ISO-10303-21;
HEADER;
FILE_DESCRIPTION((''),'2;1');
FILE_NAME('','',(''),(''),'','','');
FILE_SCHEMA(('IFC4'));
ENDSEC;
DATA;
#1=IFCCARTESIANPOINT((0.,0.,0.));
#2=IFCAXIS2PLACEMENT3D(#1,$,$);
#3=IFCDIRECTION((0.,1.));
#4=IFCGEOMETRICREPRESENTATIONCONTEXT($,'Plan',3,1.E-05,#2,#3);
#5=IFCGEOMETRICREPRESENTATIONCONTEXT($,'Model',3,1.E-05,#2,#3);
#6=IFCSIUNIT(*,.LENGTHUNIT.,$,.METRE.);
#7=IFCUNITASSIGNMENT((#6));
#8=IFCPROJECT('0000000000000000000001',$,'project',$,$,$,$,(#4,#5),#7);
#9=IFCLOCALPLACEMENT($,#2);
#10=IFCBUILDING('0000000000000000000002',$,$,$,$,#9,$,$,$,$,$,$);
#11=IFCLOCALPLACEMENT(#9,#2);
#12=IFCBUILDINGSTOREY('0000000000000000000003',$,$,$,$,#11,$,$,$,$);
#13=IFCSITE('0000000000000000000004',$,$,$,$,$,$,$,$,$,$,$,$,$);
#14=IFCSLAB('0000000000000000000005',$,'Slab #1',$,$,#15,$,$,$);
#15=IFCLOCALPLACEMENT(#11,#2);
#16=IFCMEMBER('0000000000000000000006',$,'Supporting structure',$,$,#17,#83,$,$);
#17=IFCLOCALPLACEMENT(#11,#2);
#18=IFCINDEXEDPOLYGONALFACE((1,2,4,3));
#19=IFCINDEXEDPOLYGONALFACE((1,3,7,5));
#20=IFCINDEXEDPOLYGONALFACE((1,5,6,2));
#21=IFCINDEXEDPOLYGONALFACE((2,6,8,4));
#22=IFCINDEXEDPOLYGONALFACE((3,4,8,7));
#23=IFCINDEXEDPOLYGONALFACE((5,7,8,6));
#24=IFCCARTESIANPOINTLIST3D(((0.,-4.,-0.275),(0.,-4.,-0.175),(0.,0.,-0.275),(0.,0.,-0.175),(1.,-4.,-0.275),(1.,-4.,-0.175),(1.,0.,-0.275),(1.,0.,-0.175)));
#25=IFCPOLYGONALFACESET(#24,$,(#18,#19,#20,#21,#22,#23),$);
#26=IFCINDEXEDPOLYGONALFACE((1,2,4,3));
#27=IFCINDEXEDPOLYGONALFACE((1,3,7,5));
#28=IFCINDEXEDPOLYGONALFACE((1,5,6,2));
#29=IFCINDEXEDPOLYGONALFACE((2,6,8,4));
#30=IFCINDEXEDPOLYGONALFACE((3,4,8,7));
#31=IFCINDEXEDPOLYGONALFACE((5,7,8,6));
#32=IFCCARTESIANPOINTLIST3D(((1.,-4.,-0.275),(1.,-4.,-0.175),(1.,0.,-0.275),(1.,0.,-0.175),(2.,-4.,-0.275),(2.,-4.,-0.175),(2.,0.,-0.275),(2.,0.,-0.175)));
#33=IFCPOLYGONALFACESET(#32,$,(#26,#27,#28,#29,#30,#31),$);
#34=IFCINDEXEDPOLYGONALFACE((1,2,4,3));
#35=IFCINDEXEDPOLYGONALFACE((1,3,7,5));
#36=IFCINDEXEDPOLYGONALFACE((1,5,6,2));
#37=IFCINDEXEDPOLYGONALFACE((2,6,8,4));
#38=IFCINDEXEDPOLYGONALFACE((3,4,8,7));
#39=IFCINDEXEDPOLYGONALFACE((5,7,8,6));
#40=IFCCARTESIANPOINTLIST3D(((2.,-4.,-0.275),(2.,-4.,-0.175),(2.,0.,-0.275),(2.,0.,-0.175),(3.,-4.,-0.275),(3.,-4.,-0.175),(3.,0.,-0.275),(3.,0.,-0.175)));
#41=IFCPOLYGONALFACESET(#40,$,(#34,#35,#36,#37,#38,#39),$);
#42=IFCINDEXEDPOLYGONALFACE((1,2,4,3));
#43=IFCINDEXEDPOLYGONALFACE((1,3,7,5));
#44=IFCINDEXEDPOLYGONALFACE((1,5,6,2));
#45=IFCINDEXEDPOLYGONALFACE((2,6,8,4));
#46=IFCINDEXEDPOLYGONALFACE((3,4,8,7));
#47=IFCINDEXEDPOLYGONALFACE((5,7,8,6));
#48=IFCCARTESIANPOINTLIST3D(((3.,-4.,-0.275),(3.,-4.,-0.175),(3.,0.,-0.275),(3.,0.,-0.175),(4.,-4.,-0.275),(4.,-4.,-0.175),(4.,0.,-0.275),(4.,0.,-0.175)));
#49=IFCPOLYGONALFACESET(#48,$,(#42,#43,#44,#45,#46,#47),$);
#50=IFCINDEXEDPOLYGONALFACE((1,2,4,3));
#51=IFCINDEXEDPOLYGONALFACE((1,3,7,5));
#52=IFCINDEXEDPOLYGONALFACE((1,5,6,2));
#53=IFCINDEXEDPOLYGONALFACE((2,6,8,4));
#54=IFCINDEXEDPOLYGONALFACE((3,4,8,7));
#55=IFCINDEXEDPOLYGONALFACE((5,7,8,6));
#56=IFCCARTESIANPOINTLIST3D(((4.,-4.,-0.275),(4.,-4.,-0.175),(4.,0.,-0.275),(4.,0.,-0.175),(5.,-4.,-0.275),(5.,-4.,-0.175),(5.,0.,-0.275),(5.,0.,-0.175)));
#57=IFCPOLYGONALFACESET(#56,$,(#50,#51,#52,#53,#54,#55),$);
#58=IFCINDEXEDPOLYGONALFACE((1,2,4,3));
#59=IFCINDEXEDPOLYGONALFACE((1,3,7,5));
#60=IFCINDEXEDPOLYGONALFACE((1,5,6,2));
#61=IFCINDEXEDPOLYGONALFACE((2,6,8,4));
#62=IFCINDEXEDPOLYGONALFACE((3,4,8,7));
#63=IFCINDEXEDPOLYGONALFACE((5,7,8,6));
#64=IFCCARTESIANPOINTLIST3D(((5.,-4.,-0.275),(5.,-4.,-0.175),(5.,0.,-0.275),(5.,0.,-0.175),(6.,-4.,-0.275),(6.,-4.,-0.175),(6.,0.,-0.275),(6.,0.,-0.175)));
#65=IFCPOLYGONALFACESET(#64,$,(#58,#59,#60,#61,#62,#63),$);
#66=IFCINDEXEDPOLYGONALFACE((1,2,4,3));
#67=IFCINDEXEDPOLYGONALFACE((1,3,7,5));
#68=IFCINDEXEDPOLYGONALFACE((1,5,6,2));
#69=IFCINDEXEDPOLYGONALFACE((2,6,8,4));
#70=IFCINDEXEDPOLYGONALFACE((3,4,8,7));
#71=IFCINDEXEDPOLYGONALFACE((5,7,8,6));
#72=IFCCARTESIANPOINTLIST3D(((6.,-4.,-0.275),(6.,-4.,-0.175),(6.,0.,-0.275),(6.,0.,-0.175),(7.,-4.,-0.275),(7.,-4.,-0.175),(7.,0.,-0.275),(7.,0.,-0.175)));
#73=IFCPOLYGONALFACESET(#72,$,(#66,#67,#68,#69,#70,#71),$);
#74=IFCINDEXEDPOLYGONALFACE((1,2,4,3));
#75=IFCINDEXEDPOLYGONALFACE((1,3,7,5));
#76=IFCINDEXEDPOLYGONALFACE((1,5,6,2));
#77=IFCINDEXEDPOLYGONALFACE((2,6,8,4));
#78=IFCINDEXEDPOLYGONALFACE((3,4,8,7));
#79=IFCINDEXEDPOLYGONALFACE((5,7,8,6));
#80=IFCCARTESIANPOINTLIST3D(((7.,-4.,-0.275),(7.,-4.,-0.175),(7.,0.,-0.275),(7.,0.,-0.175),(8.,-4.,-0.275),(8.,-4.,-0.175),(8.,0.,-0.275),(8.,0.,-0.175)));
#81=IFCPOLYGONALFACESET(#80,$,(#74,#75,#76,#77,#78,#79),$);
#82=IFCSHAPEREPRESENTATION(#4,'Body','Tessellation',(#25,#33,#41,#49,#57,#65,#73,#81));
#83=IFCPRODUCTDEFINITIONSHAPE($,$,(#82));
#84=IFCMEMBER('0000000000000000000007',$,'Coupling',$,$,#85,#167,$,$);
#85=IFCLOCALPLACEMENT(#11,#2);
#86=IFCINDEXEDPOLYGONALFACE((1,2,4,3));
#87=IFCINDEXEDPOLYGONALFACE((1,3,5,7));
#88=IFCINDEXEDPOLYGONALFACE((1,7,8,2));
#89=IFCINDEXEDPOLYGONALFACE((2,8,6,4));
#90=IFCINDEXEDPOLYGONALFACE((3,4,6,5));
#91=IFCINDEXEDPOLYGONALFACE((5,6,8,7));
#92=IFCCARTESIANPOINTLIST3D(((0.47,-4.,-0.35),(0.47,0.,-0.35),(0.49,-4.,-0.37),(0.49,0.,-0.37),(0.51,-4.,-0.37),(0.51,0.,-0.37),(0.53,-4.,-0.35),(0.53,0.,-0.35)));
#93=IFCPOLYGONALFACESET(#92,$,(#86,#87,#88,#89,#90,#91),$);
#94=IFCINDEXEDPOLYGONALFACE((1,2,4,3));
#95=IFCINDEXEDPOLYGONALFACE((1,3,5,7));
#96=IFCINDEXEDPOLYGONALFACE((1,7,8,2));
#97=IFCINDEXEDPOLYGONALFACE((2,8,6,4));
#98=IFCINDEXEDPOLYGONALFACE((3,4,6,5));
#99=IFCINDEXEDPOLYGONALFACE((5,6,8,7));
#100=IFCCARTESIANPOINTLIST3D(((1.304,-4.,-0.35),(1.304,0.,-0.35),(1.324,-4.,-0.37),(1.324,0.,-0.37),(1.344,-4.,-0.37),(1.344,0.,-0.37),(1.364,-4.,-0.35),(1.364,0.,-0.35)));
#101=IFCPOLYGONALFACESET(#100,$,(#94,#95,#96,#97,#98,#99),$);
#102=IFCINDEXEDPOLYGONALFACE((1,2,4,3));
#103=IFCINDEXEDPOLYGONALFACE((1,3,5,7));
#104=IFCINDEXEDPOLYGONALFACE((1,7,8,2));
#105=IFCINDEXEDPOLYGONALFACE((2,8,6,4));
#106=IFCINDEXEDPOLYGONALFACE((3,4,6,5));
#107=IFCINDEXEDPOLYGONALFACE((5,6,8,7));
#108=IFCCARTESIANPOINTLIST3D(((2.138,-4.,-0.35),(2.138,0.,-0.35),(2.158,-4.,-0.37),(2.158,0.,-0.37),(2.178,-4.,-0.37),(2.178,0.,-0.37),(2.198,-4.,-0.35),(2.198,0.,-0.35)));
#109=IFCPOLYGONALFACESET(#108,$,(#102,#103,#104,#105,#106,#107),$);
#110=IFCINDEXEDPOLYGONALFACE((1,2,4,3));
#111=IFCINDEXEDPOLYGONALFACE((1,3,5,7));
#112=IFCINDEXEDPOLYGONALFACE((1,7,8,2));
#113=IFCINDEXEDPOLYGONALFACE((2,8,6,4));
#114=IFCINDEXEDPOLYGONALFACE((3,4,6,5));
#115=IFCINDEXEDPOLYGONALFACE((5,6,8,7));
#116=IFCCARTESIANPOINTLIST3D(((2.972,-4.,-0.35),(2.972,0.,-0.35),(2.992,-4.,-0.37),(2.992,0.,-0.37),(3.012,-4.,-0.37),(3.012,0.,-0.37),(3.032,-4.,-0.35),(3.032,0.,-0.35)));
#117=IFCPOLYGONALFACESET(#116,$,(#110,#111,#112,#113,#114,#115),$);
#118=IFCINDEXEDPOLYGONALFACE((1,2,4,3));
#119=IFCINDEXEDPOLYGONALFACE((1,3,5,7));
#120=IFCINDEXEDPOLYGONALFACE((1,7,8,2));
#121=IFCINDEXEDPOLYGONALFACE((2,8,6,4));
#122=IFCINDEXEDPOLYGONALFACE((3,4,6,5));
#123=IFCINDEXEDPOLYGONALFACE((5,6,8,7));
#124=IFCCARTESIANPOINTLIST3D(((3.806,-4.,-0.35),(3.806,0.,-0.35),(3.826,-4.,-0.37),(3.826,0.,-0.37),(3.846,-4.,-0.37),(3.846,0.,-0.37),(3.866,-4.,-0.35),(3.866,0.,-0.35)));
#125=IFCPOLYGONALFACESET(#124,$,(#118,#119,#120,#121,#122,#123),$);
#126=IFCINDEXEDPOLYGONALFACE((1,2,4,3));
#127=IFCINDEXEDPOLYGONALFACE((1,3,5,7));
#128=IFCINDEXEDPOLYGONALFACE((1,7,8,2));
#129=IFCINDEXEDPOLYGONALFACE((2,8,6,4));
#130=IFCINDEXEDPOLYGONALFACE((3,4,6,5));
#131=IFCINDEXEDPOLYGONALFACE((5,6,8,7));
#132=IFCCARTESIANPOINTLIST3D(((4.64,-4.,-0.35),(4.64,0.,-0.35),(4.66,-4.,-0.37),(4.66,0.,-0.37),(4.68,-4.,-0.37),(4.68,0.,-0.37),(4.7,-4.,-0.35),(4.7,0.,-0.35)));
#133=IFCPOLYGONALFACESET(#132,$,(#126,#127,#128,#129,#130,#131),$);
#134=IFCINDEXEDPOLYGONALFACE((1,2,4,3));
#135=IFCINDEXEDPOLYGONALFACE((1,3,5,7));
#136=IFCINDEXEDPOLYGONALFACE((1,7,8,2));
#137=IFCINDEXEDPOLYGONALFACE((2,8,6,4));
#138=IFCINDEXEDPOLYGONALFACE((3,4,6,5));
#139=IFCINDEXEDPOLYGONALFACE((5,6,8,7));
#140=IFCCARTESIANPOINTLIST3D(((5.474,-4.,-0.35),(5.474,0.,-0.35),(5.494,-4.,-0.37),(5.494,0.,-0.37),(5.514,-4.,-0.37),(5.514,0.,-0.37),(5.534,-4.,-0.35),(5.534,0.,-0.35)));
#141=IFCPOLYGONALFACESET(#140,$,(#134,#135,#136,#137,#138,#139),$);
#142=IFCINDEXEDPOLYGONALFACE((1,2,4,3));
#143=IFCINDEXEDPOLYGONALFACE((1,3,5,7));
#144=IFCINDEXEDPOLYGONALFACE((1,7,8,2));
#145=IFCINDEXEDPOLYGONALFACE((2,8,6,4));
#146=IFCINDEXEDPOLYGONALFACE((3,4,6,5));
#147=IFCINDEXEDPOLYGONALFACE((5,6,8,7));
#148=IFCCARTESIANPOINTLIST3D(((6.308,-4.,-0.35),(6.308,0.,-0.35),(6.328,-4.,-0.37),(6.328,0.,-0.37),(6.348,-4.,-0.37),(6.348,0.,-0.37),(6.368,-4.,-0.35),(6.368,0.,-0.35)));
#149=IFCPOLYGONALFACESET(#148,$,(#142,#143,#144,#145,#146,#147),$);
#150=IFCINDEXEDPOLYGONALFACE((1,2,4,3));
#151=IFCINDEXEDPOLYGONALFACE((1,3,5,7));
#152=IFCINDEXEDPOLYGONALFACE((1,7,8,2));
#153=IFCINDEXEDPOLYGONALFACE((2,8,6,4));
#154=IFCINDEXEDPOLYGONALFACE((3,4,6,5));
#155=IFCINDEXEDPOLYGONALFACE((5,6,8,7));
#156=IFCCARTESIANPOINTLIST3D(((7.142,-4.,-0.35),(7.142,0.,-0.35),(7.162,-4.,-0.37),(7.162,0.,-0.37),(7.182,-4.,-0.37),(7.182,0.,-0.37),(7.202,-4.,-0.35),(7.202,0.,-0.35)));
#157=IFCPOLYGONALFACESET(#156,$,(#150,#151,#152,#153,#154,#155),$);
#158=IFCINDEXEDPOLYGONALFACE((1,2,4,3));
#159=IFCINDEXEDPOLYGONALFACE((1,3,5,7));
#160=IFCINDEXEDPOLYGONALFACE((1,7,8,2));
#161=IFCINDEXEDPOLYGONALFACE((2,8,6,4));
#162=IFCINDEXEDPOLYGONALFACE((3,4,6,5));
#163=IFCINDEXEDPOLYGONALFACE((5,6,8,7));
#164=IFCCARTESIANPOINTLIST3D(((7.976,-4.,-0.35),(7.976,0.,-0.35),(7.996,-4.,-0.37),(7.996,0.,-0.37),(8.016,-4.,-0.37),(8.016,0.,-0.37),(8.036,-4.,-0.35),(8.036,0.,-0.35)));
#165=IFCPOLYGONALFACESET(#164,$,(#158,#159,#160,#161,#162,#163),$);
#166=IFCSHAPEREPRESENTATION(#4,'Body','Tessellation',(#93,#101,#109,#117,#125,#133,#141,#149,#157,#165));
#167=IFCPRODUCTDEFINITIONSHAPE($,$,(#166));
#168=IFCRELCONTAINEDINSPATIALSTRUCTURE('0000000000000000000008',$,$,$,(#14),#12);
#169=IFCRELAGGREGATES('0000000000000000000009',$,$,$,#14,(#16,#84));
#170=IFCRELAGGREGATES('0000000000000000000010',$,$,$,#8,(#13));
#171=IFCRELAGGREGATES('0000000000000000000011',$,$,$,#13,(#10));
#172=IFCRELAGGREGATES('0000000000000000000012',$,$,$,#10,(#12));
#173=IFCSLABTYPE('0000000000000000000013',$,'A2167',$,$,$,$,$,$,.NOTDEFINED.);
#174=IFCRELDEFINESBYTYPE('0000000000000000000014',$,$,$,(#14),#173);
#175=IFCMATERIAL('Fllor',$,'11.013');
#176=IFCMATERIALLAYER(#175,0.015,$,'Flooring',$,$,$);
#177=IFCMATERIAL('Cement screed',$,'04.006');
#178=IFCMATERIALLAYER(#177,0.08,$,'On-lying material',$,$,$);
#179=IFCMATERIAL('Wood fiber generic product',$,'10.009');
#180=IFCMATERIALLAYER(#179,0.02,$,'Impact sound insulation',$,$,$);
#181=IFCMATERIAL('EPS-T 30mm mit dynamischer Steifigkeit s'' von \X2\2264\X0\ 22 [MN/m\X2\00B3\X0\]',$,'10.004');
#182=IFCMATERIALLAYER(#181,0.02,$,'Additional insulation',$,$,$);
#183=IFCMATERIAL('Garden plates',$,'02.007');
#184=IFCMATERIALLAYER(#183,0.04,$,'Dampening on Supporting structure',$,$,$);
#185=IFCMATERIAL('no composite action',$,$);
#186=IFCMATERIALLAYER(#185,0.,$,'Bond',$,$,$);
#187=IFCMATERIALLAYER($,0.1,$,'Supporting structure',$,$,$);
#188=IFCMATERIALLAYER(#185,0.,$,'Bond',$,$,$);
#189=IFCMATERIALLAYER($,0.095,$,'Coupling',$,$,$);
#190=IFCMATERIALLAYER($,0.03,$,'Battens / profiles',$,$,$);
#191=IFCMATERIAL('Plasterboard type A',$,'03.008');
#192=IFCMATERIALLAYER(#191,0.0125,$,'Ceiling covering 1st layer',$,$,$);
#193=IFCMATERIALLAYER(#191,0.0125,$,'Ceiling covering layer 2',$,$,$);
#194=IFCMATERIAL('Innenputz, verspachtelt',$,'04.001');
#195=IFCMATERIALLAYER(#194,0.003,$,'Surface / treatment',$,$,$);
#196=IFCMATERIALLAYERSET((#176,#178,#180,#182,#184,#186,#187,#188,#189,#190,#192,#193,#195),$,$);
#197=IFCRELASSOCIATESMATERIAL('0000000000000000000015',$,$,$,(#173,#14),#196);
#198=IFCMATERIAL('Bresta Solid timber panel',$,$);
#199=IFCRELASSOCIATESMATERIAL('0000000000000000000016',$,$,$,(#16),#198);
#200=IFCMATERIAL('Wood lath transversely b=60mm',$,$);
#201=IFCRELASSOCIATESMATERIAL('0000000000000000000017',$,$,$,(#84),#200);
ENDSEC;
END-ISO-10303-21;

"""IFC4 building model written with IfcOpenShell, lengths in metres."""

from ifc_helpers import new_model, si_unit, direction, frame, frame_2d, origin, place, context, project, spatial, polyline, rectangle, outline, extrude, material, layer, layer_set, type_object, element, aggregate, save


model = new_model("IFC4")

# Units and contexts
plan_context = context("Plan", 3, precision=1e-05, world=origin(), true_north=direction((0.0, 1.0)))
model_context = context("Model", 3, precision=1e-05, world=origin(), true_north=direction((0.0, 1.0)))
ifc_project = project(units=[si_unit("LENGTHUNIT", "METRE")], contexts=[plan_context, model_context])

# Site, building, storey
site = spatial("IfcSite", under=ifc_project)
building_placement = place(None, origin())
building = spatial("IfcBuilding", under=site, at=building_placement)
storey_placement = place(building_placement, origin())
storey = spatial("IfcBuildingStorey", under=building, at=storey_placement)

# Slab, members
ifc_material_1 = material(Name="Fllor", Category="11.013")
ifc_layer_1 = layer(ifc_material_1, 0.015, Name="Flooring")
ifc_material_2 = material(Name="Cement screed", Category="04.006")
ifc_layer_2 = layer(ifc_material_2, 0.08, Name="On-lying material")
ifc_material_3 = material(Name="Wood fiber generic product", Category="10.009")
ifc_layer_3 = layer(ifc_material_3, 0.02, Name="Impact sound insulation")
ifc_material_4 = material(Name="EPS-T 30mm mit dynamischer Steifigkeit s' von ≤ 22 [MN/m³]", Category="10.004")
ifc_layer_4 = layer(ifc_material_4, 0.02, Name="Additional insulation")
ifc_material_5 = material(Name="Garden plates", Category="02.007")
ifc_layer_5 = layer(ifc_material_5, 0.04, Name="Dampening on Supporting structure")
ifc_material_6 = material(Name="no composite action")
ifc_layer_6 = layer(ifc_material_6, 0.0, Name="Bond")
ifc_layer_7 = layer(None, 0.1, Name="Supporting structure")
ifc_layer_8 = layer(ifc_material_6, 0.0, Name="Bond")
ifc_layer_9 = layer(None, 0.095, Name="Coupling")
ifc_layer_10 = layer(None, 0.03, Name="Battens / profiles")
ifc_material_7 = material(Name="Plasterboard type A", Category="03.008")
ifc_layer_11 = layer(ifc_material_7, 0.0125, Name="Ceiling covering 1st layer")
ifc_layer_12 = layer(ifc_material_7, 0.0125, Name="Ceiling covering layer 2")
ifc_material_8 = material(Name="Innenputz, verspachtelt", Category="04.001")
ifc_layer_13 = layer(ifc_material_8, 0.003, Name="Surface / treatment")
ifc_layer_set = layer_set([ifc_layer_1, ifc_layer_2, ifc_layer_3, ifc_layer_4, ifc_layer_5, ifc_layer_6, ifc_layer_7, ifc_layer_8, ifc_layer_9, ifc_layer_10, ifc_layer_11, ifc_layer_12, ifc_layer_13])
slab_type = type_object("IfcSlabType", Name="A2167", PredefinedType="NOTDEFINED", material=ifc_layer_set)
slab_placement = place(None, frame((0.0, 0.0, 0.0), z_axis=(0.0, 0.0, -1.0), x_axis=(1.0, 0.0, 0.0)))
slab = element("IfcSlab", 1, at=slab_placement, inside=storey, type_object=slab_type, material=ifc_layer_set, Name="Slab #1")
ifc_material_9 = material(Name="Bresta Solid timber panel")
member_1_placement = place(slab_placement, origin())
member_1 = element("IfcMember", 2, at=member_1_placement, material=ifc_material_9, Name="Supporting structure", context=plan_context, shape_type="SweptSolid", body=[
    extrude(rectangle(XDim=1.0, YDim=0.1, at=frame_2d((0.5, 0.05), x_axis=(1.0, 0.0))), frame((0.0, 4.0, 0.175), z_axis=(0.0, -1.0, 0.0), x_axis=(1.0, 0.0, 0.0)), (0.0, 0.0, 1.0), 4.0),
    extrude(rectangle(XDim=1.0, YDim=0.1, at=frame_2d((0.5, 0.05), x_axis=(1.0, 0.0))), frame((1.0, 4.0, 0.175), z_axis=(0.0, -1.0, 0.0), x_axis=(1.0, 0.0, 0.0)), (0.0, 0.0, 1.0), 4.0),
    extrude(rectangle(XDim=1.0, YDim=0.1, at=frame_2d((0.5, 0.05), x_axis=(1.0, 0.0))), frame((2.0, 4.0, 0.175), z_axis=(0.0, -1.0, 0.0), x_axis=(1.0, 0.0, 0.0)), (0.0, 0.0, 1.0), 4.0),
    extrude(rectangle(XDim=1.0, YDim=0.1, at=frame_2d((0.5, 0.05), x_axis=(1.0, 0.0))), frame((3.0, 4.0, 0.175), z_axis=(0.0, -1.0, 0.0), x_axis=(1.0, 0.0, 0.0)), (0.0, 0.0, 1.0), 4.0),
    extrude(rectangle(XDim=1.0, YDim=0.1, at=frame_2d((0.5, 0.05), x_axis=(1.0, 0.0))), frame((4.0, 4.0, 0.175), z_axis=(0.0, -1.0, 0.0), x_axis=(1.0, 0.0, 0.0)), (0.0, 0.0, 1.0), 4.0),
    extrude(rectangle(XDim=1.0, YDim=0.1, at=frame_2d((0.5, 0.05), x_axis=(1.0, 0.0))), frame((5.0, 4.0, 0.175), z_axis=(0.0, -1.0, 0.0), x_axis=(1.0, 0.0, 0.0)), (0.0, 0.0, 1.0), 4.0),
    extrude(rectangle(XDim=1.0, YDim=0.1, at=frame_2d((0.5, 0.05), x_axis=(1.0, 0.0))), frame((6.0, 4.0, 0.175), z_axis=(0.0, -1.0, 0.0), x_axis=(1.0, 0.0, 0.0)), (0.0, 0.0, 1.0), 4.0),
    extrude(rectangle(XDim=1.0, YDim=0.1, at=frame_2d((0.5, 0.05), x_axis=(1.0, 0.0))), frame((7.0, 4.0, 0.175), z_axis=(0.0, -1.0, 0.0), x_axis=(1.0, 0.0, 0.0)), (0.0, 0.0, 1.0), 4.0),
])
ifc_material_10 = material(Name="Wood lath transversely b=60mm")
member_2_placement = place(slab_placement, origin())
member_2 = element("IfcMember", 3, at=member_2_placement, material=ifc_material_10, Name="Coupling", context=plan_context, shape_type="SweptSolid", body=[
    extrude(outline(polyline([(0.0, 0.0), (0.06, 0.0), (0.04, 0.02), (0.02, 0.02), (0.0, 0.0)])), frame((0.47, 4.0, 0.35), z_axis=(0.0, -1.0, 0.0), x_axis=(1.0, 0.0, 0.0)), (0.0, 0.0, 1.0), 4.0),
    extrude(outline(polyline([(0.0, 0.0), (0.06, 0.0), (0.04, 0.02), (0.02, 0.02), (0.0, 0.0)])), frame((1.304, 4.0, 0.35), z_axis=(0.0, -1.0, 0.0), x_axis=(1.0, 0.0, 0.0)), (0.0, 0.0, 1.0), 4.0),
    extrude(outline(polyline([(0.0, 0.0), (0.06, 0.0), (0.04, 0.02), (0.02, 0.02), (0.0, 0.0)])), frame((2.138, 4.0, 0.35), z_axis=(0.0, -1.0, 0.0), x_axis=(1.0, 0.0, 0.0)), (0.0, 0.0, 1.0), 4.0),
    extrude(outline(polyline([(0.0, 0.0), (0.06, 0.0), (0.04, 0.02), (0.02, 0.02), (0.0, 0.0)])), frame((2.972, 4.0, 0.35), z_axis=(0.0, -1.0, 0.0), x_axis=(1.0, 0.0, 0.0)), (0.0, 0.0, 1.0), 4.0),
    extrude(outline(polyline([(0.0, 0.0), (0.06, 0.0), (0.04, 0.02), (0.02, 0.02), (0.0, 0.0)])), frame((3.806, 4.0, 0.35), z_axis=(0.0, -1.0, 0.0), x_axis=(1.0, 0.0, 0.0)), (0.0, 0.0, 1.0), 4.0),
    extrude(outline(polyline([(0.0, 0.0), (0.06, 0.0), (0.04, 0.02), (0.02, 0.02), (0.0, 0.0)])), frame((4.64, 4.0, 0.35), z_axis=(0.0, -1.0, 0.0), x_axis=(1.0, 0.0, 0.0)), (0.0, 0.0, 1.0), 4.0),
    extrude(outline(polyline([(0.0, 0.0), (0.06, 0.0), (0.04, 0.02), (0.02, 0.02), (0.0, 0.0)])), frame((5.474, 4.0, 0.35), z_axis=(0.0, -1.0, 0.0), x_axis=(1.0, 0.0, 0.0)), (0.0, 0.0, 1.0), 4.0),
    extrude(outline(polyline([(0.0, 0.0), (0.06, 0.0), (0.04, 0.02), (0.02, 0.02), (0.0, 0.0)])), frame((6.308, 4.0, 0.35), z_axis=(0.0, -1.0, 0.0), x_axis=(1.0, 0.0, 0.0)), (0.0, 0.0, 1.0), 4.0),
    extrude(outline(polyline([(0.0, 0.0), (0.06, 0.0), (0.04, 0.02), (0.02, 0.02), (0.0, 0.0)])), frame((7.142, 4.0, 0.35), z_axis=(0.0, -1.0, 0.0), x_axis=(1.0, 0.0, 0.0)), (0.0, 0.0, 1.0), 4.0),
    extrude(outline(polyline([(0.0, 0.0), (0.06, 0.0), (0.04, 0.02), (0.02, 0.02), (0.0, 0.0)])), frame((7.976, 4.0, 0.35), z_axis=(0.0, -1.0, 0.0), x_axis=(1.0, 0.0, 0.0)), (0.0, 0.0, 1.0), 4.0),
])
aggregate(slab, [member_1, member_2])

save(model, "model.ifc")
